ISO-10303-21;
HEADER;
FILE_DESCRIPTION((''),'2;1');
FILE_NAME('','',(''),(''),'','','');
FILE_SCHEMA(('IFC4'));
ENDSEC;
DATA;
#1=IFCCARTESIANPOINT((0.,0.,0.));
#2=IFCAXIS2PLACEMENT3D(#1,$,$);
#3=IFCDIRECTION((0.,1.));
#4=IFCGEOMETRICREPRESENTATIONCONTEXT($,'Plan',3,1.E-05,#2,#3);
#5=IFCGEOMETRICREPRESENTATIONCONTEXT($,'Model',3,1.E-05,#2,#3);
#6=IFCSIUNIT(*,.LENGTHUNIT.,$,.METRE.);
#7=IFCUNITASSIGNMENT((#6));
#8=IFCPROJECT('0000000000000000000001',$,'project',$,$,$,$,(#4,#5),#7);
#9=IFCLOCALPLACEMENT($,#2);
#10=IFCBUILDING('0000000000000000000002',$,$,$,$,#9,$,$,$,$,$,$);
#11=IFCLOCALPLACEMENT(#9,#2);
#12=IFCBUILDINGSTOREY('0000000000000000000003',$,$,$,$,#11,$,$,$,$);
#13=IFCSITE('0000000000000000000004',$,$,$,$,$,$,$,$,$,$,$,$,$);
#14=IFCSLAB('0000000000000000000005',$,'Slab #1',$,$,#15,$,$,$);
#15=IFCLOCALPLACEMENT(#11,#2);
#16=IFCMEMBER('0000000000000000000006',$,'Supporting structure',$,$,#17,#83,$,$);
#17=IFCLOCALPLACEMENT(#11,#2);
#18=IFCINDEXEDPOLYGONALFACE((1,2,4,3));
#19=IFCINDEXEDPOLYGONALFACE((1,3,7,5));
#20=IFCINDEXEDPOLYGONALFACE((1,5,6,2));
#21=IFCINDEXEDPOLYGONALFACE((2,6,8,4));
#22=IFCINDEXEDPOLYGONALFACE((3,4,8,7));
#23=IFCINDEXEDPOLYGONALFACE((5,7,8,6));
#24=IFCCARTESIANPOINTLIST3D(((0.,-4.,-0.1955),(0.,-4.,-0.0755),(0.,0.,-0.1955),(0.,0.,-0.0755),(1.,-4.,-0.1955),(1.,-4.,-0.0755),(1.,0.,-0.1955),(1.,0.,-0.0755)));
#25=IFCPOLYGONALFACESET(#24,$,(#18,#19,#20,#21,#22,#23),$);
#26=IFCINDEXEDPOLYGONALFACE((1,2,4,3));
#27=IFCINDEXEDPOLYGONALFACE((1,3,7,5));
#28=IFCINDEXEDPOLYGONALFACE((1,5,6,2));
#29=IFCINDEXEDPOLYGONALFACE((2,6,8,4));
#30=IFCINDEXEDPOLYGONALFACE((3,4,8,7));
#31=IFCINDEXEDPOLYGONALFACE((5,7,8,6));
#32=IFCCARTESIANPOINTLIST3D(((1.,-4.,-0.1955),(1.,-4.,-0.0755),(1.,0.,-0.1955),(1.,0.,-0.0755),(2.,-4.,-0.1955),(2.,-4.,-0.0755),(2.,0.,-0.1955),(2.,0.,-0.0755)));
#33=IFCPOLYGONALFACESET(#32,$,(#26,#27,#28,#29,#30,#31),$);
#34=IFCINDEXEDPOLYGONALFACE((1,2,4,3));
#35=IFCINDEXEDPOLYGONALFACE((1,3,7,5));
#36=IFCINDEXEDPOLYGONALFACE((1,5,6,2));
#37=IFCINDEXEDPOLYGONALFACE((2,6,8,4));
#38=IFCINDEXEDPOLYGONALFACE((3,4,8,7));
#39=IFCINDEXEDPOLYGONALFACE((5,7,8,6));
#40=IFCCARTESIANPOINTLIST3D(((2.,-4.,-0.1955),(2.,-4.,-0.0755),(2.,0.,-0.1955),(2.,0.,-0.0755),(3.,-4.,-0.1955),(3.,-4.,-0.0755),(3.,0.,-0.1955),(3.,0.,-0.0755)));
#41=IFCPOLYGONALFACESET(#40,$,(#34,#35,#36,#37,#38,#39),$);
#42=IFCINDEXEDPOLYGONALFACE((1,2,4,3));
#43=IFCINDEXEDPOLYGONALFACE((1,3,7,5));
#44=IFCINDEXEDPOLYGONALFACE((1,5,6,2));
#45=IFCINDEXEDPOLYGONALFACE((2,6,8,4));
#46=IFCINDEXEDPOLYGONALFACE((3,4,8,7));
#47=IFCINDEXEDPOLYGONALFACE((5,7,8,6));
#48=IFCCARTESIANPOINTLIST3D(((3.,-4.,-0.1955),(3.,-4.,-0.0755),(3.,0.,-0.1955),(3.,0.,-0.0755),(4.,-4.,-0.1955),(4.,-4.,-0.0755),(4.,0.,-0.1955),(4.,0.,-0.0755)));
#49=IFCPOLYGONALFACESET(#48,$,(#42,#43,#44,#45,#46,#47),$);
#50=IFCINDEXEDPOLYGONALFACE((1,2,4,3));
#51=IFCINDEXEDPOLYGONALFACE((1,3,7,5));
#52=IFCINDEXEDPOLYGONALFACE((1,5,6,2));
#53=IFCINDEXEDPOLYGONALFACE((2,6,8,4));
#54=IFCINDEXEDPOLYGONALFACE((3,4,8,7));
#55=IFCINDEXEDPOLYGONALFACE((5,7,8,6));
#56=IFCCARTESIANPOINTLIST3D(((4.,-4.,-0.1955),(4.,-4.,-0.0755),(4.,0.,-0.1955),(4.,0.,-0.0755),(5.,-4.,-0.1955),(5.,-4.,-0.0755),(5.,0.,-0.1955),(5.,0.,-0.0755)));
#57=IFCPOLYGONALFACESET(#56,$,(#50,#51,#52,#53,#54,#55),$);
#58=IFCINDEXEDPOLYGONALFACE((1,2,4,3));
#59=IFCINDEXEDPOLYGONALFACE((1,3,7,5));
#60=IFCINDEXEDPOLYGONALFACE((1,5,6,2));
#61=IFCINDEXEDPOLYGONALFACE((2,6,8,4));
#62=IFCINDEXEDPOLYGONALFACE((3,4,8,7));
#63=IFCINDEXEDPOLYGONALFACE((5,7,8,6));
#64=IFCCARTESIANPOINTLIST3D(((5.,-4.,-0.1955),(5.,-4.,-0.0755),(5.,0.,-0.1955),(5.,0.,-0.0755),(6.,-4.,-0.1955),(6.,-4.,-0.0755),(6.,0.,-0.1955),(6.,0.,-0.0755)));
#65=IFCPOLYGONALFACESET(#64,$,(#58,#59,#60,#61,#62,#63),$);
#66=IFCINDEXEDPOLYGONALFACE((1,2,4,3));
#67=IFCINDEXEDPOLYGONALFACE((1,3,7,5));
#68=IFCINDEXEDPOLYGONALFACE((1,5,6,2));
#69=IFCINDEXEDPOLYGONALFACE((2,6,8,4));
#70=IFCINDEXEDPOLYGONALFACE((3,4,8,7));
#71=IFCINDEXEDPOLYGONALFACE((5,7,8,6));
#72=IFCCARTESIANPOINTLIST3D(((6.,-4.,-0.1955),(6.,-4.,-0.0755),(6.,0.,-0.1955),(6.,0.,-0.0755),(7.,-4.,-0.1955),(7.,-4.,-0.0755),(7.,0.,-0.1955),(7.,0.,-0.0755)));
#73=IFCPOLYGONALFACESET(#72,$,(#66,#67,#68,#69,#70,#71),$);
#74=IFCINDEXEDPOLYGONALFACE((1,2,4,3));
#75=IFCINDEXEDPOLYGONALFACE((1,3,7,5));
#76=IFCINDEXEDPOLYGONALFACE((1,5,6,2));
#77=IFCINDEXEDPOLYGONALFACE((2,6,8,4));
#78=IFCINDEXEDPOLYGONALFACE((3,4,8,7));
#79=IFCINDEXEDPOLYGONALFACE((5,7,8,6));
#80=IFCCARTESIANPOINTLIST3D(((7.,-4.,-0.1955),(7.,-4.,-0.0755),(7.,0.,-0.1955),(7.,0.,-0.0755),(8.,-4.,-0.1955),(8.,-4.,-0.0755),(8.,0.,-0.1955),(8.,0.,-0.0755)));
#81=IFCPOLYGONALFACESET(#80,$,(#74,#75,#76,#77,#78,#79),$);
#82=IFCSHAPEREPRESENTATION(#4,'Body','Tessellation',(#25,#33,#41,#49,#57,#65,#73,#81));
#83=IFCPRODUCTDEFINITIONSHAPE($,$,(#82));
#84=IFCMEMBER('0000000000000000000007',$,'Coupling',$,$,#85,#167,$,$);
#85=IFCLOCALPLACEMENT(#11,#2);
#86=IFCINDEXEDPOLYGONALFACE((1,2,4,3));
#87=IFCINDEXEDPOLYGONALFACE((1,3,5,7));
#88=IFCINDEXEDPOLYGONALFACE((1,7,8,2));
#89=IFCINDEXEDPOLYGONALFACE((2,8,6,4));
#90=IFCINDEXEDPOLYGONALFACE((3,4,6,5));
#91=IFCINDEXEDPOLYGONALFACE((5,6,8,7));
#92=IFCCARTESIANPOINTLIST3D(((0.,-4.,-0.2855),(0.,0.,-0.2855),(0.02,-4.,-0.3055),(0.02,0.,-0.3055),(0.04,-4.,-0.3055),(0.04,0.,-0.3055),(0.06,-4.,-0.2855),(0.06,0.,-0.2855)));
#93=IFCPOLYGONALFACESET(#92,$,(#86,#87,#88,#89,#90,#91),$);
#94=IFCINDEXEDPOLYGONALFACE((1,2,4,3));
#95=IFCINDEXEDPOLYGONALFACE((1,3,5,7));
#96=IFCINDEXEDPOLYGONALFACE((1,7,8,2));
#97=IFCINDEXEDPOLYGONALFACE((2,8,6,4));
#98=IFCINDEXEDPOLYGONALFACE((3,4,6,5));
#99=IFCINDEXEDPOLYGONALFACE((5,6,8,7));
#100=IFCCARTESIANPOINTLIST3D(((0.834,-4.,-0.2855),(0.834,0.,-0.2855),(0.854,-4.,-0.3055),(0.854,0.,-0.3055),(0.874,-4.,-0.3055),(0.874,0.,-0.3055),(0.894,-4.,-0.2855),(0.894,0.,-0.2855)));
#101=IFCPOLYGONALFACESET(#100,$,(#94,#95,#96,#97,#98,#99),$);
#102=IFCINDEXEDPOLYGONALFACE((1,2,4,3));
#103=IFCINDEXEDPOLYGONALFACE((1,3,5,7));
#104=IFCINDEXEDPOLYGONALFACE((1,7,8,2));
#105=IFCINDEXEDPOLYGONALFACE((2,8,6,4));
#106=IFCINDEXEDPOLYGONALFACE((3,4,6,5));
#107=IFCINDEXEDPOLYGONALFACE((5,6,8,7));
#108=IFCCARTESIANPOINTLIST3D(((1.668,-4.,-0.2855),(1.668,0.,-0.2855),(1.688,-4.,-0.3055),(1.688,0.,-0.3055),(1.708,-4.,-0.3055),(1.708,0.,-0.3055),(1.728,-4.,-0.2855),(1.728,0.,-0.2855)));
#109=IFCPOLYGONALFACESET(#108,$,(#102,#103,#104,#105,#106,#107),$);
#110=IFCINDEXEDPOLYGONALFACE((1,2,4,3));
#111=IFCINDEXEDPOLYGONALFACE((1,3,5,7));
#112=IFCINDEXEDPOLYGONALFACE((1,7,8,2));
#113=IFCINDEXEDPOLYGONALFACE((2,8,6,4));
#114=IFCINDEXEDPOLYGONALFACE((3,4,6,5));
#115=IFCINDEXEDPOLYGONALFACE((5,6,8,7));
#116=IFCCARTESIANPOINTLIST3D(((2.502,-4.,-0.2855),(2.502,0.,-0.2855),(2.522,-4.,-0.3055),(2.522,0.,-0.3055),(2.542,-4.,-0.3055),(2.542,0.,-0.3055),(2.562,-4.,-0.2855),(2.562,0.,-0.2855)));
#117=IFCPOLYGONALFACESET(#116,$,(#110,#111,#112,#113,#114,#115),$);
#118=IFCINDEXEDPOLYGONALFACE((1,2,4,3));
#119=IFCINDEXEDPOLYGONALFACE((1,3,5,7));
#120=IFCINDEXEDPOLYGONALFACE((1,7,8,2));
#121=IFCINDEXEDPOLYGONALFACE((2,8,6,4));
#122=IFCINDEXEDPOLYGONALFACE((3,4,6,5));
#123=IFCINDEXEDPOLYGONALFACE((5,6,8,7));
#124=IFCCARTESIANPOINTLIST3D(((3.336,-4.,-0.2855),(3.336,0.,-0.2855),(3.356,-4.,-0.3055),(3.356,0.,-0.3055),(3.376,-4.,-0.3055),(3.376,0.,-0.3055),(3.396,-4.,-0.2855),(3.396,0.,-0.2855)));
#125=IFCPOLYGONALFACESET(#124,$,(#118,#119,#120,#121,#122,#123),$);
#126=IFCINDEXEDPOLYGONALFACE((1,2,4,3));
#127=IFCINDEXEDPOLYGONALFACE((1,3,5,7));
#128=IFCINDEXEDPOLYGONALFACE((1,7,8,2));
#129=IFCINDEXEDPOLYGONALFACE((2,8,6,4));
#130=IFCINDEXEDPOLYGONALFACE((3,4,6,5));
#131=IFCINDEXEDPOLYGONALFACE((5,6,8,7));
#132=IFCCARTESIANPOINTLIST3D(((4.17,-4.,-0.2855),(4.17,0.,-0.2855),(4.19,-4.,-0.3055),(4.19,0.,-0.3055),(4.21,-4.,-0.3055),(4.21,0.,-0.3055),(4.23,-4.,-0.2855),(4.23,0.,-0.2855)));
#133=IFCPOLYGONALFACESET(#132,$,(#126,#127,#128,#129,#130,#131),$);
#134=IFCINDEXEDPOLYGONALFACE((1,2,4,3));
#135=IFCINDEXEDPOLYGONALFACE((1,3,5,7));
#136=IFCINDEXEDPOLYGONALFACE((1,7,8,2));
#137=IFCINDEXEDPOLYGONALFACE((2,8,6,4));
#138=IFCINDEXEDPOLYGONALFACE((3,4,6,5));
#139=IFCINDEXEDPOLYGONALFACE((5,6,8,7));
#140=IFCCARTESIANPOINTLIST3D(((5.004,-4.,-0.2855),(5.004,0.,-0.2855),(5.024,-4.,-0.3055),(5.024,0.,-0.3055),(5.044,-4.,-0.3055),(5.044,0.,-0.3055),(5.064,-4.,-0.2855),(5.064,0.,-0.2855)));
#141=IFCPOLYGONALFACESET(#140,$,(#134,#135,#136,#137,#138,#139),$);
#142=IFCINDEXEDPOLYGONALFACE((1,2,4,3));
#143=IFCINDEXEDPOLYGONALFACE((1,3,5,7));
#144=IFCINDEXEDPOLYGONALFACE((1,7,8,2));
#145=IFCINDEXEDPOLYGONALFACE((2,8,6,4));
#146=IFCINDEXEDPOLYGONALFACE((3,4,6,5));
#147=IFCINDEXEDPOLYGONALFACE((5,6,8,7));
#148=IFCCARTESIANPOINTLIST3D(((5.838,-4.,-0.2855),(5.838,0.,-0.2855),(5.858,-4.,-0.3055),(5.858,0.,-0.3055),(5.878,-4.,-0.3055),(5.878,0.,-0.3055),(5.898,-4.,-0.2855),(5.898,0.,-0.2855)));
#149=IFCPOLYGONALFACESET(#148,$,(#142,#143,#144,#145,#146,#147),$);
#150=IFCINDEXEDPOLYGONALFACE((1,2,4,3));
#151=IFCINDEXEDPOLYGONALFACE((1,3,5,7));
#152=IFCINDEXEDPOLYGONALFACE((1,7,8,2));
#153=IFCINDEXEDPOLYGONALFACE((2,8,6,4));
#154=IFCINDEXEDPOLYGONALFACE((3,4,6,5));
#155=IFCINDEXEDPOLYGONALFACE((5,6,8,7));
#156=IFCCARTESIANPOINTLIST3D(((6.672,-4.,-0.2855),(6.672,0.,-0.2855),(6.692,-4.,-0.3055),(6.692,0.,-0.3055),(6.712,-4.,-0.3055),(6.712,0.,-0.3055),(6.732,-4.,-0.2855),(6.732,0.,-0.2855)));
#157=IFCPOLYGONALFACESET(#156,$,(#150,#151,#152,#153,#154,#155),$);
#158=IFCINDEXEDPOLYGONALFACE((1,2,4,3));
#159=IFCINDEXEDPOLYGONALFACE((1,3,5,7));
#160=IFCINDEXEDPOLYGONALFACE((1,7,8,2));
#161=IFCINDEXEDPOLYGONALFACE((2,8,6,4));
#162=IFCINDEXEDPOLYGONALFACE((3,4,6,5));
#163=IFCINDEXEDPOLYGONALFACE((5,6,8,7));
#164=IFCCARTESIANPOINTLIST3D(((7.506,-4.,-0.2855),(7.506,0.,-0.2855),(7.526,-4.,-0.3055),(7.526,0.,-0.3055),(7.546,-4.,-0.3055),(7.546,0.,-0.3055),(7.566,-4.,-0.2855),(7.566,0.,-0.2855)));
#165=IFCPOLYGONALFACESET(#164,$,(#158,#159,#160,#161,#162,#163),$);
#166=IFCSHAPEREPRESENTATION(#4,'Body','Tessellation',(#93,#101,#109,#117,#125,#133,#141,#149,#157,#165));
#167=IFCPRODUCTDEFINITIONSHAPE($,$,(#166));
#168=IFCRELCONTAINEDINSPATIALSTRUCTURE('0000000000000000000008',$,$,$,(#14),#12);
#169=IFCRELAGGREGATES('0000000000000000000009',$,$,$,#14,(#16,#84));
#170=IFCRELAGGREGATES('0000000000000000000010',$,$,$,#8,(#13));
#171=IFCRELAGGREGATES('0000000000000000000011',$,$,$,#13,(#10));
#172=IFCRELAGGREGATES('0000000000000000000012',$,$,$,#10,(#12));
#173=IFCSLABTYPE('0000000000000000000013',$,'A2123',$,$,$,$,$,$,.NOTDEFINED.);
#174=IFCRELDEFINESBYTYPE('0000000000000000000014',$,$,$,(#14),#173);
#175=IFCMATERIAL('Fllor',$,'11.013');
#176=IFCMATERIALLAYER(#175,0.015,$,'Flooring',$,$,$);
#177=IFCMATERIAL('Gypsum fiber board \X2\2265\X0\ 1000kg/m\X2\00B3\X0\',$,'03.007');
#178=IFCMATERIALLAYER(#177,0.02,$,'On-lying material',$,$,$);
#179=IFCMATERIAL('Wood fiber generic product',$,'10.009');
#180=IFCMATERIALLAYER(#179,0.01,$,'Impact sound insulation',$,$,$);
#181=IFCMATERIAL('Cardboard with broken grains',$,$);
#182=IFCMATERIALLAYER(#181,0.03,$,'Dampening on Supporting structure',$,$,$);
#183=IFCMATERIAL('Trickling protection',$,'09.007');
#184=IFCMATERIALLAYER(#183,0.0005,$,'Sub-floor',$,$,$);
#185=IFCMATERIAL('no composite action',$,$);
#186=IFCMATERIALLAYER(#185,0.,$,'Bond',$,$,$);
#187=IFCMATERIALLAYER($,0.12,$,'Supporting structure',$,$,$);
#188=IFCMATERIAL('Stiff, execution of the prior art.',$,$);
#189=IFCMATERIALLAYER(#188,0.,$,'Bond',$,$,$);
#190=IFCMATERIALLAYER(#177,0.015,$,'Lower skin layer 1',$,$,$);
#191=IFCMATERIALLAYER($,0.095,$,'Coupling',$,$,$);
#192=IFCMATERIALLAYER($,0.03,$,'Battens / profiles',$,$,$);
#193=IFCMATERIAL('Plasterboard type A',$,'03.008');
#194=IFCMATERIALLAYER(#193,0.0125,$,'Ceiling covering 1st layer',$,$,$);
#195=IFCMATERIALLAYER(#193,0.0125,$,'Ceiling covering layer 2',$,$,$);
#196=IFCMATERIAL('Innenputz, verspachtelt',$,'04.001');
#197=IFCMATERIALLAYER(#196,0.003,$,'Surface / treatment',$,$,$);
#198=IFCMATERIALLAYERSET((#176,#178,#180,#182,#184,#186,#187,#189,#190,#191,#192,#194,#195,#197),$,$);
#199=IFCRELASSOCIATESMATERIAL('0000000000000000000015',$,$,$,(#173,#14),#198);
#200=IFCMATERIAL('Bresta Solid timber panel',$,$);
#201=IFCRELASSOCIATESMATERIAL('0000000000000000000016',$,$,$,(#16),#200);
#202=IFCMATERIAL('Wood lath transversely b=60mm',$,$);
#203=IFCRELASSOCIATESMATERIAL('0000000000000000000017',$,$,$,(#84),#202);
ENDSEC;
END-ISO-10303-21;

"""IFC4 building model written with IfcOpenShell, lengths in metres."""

from ifc_helpers import new_model, si_unit, direction, frame, frame_2d, origin, place, context, project, spatial, polyline, rectangle, outline, extrude, material, layer, layer_set, type_object, element, aggregate, save


model = new_model("IFC4")

# Units and contexts
plan_context = context("Plan", 3, precision=1e-05, world=origin(), true_north=direction((0.0, 1.0)))
model_context = context("Model", 3, precision=1e-05, world=origin(), true_north=direction((0.0, 1.0)))
ifc_project = project(units=[si_unit("LENGTHUNIT", "METRE")], contexts=[plan_context, model_context])

# Site, building, storey
site = spatial("IfcSite", under=ifc_project)
building_placement = place(None, origin())
building = spatial("IfcBuilding", under=site, at=building_placement)
storey_placement = place(building_placement, origin())
storey = spatial("IfcBuildingStorey", under=building, at=storey_placement)

# Slab, members
ifc_material_1 = material(Name="Fllor", Category="11.013")
ifc_layer_1 = layer(ifc_material_1, 0.015, Name="Flooring")
ifc_material_2 = material(Name="Gypsum fiber board ≥ 1000kg/m³", Category="03.007")
ifc_layer_2 = layer(ifc_material_2, 0.02, Name="On-lying material")
ifc_material_3 = material(Name="Wood fiber generic product", Category="10.009")
ifc_layer_3 = layer(ifc_material_3, 0.01, Name="Impact sound insulation")
ifc_material_4 = material(Name="Cardboard with broken grains")
ifc_layer_4 = layer(ifc_material_4, 0.03, Name="Dampening on Supporting structure")
ifc_material_5 = material(Name="Trickling protection", Category="09.007")
ifc_layer_5 = layer(ifc_material_5, 0.0005, Name="Sub-floor")
ifc_material_6 = material(Name="no composite action")
ifc_layer_6 = layer(ifc_material_6, 0.0, Name="Bond")
ifc_layer_7 = layer(None, 0.12, Name="Supporting structure")
ifc_material_7 = material(Name="Stiff, execution of the prior art.")
ifc_layer_8 = layer(ifc_material_7, 0.0, Name="Bond")
ifc_layer_9 = layer(ifc_material_2, 0.015, Name="Lower skin layer 1")
ifc_layer_10 = layer(None, 0.095, Name="Coupling")
ifc_layer_11 = layer(None, 0.03, Name="Battens / profiles")
ifc_material_8 = material(Name="Plasterboard type A", Category="03.008")
ifc_layer_12 = layer(ifc_material_8, 0.0125, Name="Ceiling covering 1st layer")
ifc_layer_13 = layer(ifc_material_8, 0.0125, Name="Ceiling covering layer 2")
ifc_material_9 = material(Name="Innenputz, verspachtelt", Category="04.001")
ifc_layer_14 = layer(ifc_material_9, 0.003, Name="Surface / treatment")
ifc_layer_set = layer_set([ifc_layer_1, ifc_layer_2, ifc_layer_3, ifc_layer_4, ifc_layer_5, ifc_layer_6, ifc_layer_7, ifc_layer_8, ifc_layer_9, ifc_layer_10, ifc_layer_11, ifc_layer_12, ifc_layer_13, ifc_layer_14])
slab_type = type_object("IfcSlabType", Name="A2123", PredefinedType="NOTDEFINED", material=ifc_layer_set)
slab_placement = place(None, frame((0.0, 0.0, 0.0), z_axis=(0.0, 0.0, -1.0), x_axis=(1.0, 0.0, 0.0)))
slab = element("IfcSlab", 1, at=slab_placement, inside=storey, type_object=slab_type, material=ifc_layer_set, Name="Slab #1")
ifc_material_10 = material(Name="Bresta Solid timber panel")
member_1_placement = place(slab_placement, origin())
member_1 = element("IfcMember", 2, at=member_1_placement, material=ifc_material_10, Name="Supporting structure", context=plan_context, shape_type="SweptSolid", body=[
    extrude(rectangle(XDim=1.0, YDim=0.12, at=frame_2d((0.5, 0.06), x_axis=(1.0, 0.0))), frame((0.0, 4.0, 0.0755), z_axis=(0.0, -1.0, 0.0), x_axis=(1.0, 0.0, 0.0)), (0.0, 0.0, 1.0), 4.0),
    extrude(rectangle(XDim=1.0, YDim=0.12, at=frame_2d((0.5, 0.06), x_axis=(1.0, 0.0))), frame((1.0, 4.0, 0.0755), z_axis=(0.0, -1.0, 0.0), x_axis=(1.0, 0.0, 0.0)), (0.0, 0.0, 1.0), 4.0),
    extrude(rectangle(XDim=1.0, YDim=0.12, at=frame_2d((0.5, 0.06), x_axis=(1.0, 0.0))), frame((2.0, 4.0, 0.0755), z_axis=(0.0, -1.0, 0.0), x_axis=(1.0, 0.0, 0.0)), (0.0, 0.0, 1.0), 4.0),
    extrude(rectangle(XDim=1.0, YDim=0.12, at=frame_2d((0.5, 0.06), x_axis=(1.0, 0.0))), frame((3.0, 4.0, 0.0755), z_axis=(0.0, -1.0, 0.0), x_axis=(1.0, 0.0, 0.0)), (0.0, 0.0, 1.0), 4.0),
    extrude(rectangle(XDim=1.0, YDim=0.12, at=frame_2d((0.5, 0.06), x_axis=(1.0, 0.0))), frame((4.0, 4.0, 0.0755), z_axis=(0.0, -1.0, 0.0), x_axis=(1.0, 0.0, 0.0)), (0.0, 0.0, 1.0), 4.0),
    extrude(rectangle(XDim=1.0, YDim=0.12, at=frame_2d((0.5, 0.06), x_axis=(1.0, 0.0))), frame((5.0, 4.0, 0.0755), z_axis=(0.0, -1.0, 0.0), x_axis=(1.0, 0.0, 0.0)), (0.0, 0.0, 1.0), 4.0),
    extrude(rectangle(XDim=1.0, YDim=0.12, at=frame_2d((0.5, 0.06), x_axis=(1.0, 0.0))), frame((6.0, 4.0, 0.0755), z_axis=(0.0, -1.0, 0.0), x_axis=(1.0, 0.0, 0.0)), (0.0, 0.0, 1.0), 4.0),
    extrude(rectangle(XDim=1.0, YDim=0.12, at=frame_2d((0.5, 0.06), x_axis=(1.0, 0.0))), frame((7.0, 4.0, 0.0755), z_axis=(0.0, -1.0, 0.0), x_axis=(1.0, 0.0, 0.0)), (0.0, 0.0, 1.0), 4.0),
])
ifc_material_11 = material(Name="Wood lath transversely b=60mm")
member_2_placement = place(slab_placement, origin())
member_2 = element("IfcMember", 3, at=member_2_placement, material=ifc_material_11, Name="Coupling", context=plan_context, shape_type="SweptSolid", body=[
    extrude(outline(polyline([(0.0, 0.0), (0.06, 0.0), (0.04, 0.02), (0.02, 0.02), (0.0, 0.0)])), frame((0.0, 4.0, 0.2855), z_axis=(0.0, -1.0, 0.0), x_axis=(1.0, 0.0, 0.0)), (0.0, 0.0, 1.0), 4.0),
    extrude(outline(polyline([(0.0, 0.0), (0.06, 0.0), (0.04, 0.02), (0.02, 0.02), (0.0, 0.0)])), frame((0.834, 4.0, 0.2855), z_axis=(0.0, -1.0, 0.0), x_axis=(1.0, 0.0, 0.0)), (0.0, 0.0, 1.0), 4.0),
    extrude(outline(polyline([(0.0, 0.0), (0.06, 0.0), (0.04, 0.02), (0.02, 0.02), (0.0, 0.0)])), frame((1.668, 4.0, 0.2855), z_axis=(0.0, -1.0, 0.0), x_axis=(1.0, 0.0, 0.0)), (0.0, 0.0, 1.0), 4.0),
    extrude(outline(polyline([(0.0, 0.0), (0.06, 0.0), (0.04, 0.02), (0.02, 0.02), (0.0, 0.0)])), frame((2.502, 4.0, 0.2855), z_axis=(0.0, -1.0, 0.0), x_axis=(1.0, 0.0, 0.0)), (0.0, 0.0, 1.0), 4.0),
    extrude(outline(polyline([(0.0, 0.0), (0.06, 0.0), (0.04, 0.02), (0.02, 0.02), (0.0, 0.0)])), frame((3.336, 4.0, 0.2855), z_axis=(0.0, -1.0, 0.0), x_axis=(1.0, 0.0, 0.0)), (0.0, 0.0, 1.0), 4.0),
    extrude(outline(polyline([(0.0, 0.0), (0.06, 0.0), (0.04, 0.02), (0.02, 0.02), (0.0, 0.0)])), frame((4.17, 4.0, 0.2855), z_axis=(0.0, -1.0, 0.0), x_axis=(1.0, 0.0, 0.0)), (0.0, 0.0, 1.0), 4.0),
    extrude(outline(polyline([(0.0, 0.0), (0.06, 0.0), (0.04, 0.02), (0.02, 0.02), (0.0, 0.0)])), frame((5.004, 4.0, 0.2855), z_axis=(0.0, -1.0, 0.0), x_axis=(1.0, 0.0, 0.0)), (0.0, 0.0, 1.0), 4.0),
    extrude(outline(polyline([(0.0, 0.0), (0.06, 0.0), (0.04, 0.02), (0.02, 0.02), (0.0, 0.0)])), frame((5.838, 4.0, 0.2855), z_axis=(0.0, -1.0, 0.0), x_axis=(1.0, 0.0, 0.0)), (0.0, 0.0, 1.0), 4.0),
    extrude(outline(polyline([(0.0, 0.0), (0.06, 0.0), (0.04, 0.02), (0.02, 0.02), (0.0, 0.0)])), frame((6.672, 4.0, 0.2855), z_axis=(0.0, -1.0, 0.0), x_axis=(1.0, 0.0, 0.0)), (0.0, 0.0, 1.0), 4.0),
    extrude(outline(polyline([(0.0, 0.0), (0.06, 0.0), (0.04, 0.02), (0.02, 0.02), (0.0, 0.0)])), frame((7.506, 4.0, 0.2855), z_axis=(0.0, -1.0, 0.0), x_axis=(1.0, 0.0, 0.0)), (0.0, 0.0, 1.0), 4.0),
])
aggregate(slab, [member_1, member_2])

save(model, "model.ifc")
